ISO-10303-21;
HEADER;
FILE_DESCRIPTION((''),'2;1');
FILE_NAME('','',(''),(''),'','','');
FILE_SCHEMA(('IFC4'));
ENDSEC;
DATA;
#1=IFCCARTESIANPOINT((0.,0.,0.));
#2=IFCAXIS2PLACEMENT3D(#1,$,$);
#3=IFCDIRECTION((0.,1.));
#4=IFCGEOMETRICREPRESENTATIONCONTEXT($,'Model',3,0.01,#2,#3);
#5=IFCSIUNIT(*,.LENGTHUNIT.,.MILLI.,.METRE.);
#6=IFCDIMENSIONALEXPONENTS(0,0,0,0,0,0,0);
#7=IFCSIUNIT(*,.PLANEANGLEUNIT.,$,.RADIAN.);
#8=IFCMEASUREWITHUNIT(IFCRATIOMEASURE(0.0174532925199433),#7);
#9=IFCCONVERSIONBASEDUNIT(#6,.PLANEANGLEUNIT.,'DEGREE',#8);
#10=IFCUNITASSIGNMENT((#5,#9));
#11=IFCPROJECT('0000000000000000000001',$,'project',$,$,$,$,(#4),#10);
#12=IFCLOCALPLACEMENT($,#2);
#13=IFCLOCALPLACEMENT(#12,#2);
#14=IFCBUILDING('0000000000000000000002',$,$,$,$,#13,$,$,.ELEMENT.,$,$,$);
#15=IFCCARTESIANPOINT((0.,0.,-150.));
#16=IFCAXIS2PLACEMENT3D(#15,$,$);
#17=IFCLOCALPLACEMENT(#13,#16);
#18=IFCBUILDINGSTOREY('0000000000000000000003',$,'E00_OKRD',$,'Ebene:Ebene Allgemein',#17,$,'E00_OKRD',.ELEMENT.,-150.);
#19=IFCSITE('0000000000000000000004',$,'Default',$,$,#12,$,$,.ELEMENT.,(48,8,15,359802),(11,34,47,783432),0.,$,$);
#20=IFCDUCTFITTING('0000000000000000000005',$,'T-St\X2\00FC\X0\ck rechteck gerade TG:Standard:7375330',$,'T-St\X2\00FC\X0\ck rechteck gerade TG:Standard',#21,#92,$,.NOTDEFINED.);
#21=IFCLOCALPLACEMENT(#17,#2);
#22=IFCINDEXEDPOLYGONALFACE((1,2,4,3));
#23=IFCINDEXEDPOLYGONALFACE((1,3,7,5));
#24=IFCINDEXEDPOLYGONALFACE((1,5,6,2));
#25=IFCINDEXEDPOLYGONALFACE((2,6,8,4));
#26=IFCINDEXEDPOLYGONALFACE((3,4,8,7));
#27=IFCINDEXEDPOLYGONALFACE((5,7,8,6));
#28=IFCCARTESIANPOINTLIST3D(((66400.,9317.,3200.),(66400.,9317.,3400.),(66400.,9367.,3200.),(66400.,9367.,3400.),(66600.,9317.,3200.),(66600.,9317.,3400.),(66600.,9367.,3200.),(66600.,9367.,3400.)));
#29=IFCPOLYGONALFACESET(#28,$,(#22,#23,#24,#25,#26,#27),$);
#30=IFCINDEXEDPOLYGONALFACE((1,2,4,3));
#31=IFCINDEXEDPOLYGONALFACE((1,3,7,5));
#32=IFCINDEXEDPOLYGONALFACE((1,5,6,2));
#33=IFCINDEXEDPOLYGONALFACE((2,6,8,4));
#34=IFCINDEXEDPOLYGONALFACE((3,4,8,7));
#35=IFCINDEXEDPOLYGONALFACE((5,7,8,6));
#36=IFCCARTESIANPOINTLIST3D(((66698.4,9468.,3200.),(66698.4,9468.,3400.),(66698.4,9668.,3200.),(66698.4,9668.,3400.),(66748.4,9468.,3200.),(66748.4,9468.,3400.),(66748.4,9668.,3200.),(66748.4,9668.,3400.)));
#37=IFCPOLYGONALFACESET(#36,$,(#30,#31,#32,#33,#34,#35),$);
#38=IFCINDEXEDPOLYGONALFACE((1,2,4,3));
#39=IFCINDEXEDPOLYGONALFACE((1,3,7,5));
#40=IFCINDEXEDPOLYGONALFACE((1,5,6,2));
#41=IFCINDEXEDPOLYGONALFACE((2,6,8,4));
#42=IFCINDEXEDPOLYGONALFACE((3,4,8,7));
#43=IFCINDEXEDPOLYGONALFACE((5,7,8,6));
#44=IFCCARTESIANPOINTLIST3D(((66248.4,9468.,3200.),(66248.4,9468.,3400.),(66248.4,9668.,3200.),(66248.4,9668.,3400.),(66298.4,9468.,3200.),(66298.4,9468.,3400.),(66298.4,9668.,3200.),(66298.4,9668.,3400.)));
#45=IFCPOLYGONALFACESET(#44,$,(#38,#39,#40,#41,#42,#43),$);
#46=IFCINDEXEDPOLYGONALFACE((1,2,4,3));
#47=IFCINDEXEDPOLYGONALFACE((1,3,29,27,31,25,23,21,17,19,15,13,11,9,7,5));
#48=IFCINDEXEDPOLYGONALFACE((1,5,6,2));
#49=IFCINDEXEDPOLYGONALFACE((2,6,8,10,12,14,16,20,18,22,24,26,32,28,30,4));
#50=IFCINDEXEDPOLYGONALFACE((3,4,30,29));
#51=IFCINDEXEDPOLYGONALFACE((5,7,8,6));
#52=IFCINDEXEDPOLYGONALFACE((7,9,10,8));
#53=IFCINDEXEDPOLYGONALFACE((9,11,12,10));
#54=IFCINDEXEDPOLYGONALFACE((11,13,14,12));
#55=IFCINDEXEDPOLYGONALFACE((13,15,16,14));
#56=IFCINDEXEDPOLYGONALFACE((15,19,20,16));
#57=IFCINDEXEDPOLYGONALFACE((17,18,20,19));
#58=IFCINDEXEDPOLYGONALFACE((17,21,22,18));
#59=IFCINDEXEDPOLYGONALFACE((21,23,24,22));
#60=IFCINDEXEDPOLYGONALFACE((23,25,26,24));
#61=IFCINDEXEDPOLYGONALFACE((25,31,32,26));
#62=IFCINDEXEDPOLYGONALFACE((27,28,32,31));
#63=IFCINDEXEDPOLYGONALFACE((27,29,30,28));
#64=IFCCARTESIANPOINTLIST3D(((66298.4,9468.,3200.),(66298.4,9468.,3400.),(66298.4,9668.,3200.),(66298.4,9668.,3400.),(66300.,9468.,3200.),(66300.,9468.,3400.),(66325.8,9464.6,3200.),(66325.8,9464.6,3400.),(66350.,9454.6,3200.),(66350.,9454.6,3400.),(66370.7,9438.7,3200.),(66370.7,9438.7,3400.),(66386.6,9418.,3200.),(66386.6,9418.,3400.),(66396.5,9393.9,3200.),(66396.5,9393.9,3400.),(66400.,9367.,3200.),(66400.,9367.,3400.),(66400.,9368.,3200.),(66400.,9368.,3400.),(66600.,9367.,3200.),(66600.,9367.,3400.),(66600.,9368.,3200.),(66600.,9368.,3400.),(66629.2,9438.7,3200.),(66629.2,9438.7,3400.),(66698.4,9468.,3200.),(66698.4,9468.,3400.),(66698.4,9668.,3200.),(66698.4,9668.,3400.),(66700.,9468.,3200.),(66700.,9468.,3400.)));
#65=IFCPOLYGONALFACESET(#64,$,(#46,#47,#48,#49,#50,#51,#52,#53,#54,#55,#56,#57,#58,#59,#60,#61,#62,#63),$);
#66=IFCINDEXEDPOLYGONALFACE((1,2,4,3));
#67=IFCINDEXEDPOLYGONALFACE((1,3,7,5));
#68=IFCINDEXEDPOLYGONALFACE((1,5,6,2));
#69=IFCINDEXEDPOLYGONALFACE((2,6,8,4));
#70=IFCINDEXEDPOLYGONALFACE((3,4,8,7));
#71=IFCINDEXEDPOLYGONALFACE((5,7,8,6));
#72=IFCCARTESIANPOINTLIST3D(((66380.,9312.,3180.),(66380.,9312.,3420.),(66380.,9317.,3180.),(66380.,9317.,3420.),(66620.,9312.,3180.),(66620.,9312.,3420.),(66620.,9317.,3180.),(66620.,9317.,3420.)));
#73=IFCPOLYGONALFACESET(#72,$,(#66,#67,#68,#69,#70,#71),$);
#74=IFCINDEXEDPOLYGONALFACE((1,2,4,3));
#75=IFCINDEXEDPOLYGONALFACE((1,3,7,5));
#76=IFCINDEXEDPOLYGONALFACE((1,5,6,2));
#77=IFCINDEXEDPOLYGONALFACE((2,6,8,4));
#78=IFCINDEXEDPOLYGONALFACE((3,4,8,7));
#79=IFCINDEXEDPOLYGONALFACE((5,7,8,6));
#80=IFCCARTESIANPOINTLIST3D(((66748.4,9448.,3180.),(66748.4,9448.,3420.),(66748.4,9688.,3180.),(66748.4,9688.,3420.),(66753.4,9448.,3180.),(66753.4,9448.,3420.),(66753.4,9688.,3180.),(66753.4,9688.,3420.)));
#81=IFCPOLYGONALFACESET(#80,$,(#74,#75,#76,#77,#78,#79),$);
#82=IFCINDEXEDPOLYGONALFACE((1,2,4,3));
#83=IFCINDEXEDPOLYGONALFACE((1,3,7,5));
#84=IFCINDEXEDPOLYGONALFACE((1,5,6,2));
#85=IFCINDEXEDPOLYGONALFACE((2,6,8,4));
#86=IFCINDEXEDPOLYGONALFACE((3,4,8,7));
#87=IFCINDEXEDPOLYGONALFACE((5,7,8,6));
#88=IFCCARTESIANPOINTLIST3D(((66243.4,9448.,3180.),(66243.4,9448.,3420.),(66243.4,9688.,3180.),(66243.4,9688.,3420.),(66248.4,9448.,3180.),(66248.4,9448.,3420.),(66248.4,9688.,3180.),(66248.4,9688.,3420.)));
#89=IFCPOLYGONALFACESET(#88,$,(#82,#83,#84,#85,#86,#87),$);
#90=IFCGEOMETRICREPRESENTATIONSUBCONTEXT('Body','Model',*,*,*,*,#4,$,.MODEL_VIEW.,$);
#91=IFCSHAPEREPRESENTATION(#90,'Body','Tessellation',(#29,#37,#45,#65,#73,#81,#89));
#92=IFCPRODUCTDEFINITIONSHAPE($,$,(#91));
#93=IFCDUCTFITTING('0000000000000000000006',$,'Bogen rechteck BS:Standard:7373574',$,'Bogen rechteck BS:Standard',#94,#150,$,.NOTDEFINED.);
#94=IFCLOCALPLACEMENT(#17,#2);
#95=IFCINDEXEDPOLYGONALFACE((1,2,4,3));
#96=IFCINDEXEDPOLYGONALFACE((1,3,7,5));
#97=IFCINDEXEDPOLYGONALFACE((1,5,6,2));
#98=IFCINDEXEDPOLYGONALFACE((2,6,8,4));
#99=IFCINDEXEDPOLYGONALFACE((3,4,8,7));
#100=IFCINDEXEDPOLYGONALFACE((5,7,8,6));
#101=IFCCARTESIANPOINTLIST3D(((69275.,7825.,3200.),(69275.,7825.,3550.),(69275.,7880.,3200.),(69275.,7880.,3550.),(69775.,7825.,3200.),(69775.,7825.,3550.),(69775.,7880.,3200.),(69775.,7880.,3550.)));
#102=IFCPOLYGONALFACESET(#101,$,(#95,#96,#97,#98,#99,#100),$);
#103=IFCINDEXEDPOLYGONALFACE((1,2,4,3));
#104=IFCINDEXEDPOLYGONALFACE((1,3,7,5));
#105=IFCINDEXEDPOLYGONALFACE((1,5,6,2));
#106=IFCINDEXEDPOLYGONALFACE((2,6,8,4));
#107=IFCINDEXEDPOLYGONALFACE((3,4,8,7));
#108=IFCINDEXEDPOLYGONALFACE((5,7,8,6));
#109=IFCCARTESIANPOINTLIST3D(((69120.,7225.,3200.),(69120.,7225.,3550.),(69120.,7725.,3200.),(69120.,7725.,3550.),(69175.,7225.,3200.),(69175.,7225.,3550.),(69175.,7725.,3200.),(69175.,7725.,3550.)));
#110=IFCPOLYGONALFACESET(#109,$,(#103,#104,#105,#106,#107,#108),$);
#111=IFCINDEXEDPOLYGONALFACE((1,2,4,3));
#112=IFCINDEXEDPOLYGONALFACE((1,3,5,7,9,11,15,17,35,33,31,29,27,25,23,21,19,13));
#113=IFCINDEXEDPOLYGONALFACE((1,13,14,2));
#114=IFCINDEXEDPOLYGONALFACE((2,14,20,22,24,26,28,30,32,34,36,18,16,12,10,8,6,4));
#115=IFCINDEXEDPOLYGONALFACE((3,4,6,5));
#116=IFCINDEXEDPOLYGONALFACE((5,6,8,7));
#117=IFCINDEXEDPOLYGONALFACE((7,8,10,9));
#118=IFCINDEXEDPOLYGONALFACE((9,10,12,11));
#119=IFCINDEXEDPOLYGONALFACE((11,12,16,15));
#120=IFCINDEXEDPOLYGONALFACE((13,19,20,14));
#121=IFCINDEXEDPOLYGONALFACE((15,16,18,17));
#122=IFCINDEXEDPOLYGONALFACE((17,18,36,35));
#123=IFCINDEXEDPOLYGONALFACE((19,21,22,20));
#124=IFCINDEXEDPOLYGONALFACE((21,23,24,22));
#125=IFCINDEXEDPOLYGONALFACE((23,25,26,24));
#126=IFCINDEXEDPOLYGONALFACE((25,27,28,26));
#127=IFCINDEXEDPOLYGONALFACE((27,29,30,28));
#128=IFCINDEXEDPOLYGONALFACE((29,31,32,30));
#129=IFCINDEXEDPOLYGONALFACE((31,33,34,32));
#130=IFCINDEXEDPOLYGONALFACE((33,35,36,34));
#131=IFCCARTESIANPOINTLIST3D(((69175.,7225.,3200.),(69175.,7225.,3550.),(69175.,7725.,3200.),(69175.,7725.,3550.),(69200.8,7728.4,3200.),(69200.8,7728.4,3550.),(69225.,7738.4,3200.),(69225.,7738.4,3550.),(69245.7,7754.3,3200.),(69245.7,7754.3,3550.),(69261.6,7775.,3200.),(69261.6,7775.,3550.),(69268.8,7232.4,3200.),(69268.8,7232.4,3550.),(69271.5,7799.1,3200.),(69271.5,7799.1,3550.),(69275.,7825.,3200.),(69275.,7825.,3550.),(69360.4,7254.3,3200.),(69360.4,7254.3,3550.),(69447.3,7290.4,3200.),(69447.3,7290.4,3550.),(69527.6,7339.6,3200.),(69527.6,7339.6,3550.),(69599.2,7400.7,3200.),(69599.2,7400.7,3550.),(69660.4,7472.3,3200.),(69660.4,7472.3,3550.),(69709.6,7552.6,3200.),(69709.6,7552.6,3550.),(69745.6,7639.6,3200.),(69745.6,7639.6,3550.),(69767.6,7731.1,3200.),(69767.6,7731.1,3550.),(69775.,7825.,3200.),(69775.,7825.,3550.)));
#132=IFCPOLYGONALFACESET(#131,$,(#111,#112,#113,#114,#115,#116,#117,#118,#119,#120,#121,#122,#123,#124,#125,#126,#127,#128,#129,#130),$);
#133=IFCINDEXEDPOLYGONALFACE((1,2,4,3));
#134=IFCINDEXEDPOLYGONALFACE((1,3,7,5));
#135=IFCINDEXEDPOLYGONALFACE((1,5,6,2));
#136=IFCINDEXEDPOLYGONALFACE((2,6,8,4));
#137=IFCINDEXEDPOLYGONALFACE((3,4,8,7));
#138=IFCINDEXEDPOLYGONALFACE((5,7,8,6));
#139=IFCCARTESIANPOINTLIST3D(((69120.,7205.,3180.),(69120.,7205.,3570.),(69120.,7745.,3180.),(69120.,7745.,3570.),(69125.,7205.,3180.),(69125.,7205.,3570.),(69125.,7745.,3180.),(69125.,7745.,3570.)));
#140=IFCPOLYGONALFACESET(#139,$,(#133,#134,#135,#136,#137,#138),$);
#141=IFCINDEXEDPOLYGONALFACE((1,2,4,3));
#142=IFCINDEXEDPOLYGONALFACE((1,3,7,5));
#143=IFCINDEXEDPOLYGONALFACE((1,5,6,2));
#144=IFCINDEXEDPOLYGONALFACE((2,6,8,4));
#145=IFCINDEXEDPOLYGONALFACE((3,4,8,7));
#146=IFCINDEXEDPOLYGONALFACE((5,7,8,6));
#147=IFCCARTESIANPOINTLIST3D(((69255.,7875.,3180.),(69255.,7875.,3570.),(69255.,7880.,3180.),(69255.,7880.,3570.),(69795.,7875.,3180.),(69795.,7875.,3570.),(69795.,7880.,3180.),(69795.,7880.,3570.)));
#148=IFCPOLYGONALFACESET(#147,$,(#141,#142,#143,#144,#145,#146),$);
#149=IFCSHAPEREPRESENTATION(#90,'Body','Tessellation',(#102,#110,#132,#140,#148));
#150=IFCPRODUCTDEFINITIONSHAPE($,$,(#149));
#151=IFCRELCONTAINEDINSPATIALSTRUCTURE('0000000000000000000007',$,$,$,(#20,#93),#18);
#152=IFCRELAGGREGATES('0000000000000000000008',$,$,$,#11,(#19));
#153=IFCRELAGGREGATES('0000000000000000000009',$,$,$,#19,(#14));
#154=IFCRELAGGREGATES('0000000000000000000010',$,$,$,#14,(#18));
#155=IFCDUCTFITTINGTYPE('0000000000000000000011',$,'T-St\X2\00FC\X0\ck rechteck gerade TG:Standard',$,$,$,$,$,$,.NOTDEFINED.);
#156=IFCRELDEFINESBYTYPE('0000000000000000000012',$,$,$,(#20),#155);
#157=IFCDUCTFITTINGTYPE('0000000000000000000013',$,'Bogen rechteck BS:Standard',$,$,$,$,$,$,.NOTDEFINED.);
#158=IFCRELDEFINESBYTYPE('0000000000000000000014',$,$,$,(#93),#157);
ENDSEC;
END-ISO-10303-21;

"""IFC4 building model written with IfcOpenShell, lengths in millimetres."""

from ifc_helpers import new_model, entity, si_unit, converted_unit, direction, frame, frame_2d, origin, origin_2d_with_axis, place, context, subcontext, project, spatial, polyline, circle_curve, parameter, trimmed, segment, composite_curve, rectangle, outline, extrude, source, transform, mapped, type_object, type_shapes, element, save


model = new_model("IFC4")

# Units and contexts
model_context = context("Model", 3, precision=0.01, world=origin(), true_north=direction((0.0, 1.0)))
body_context = subcontext(model_context, "Body", "Model", "MODEL_VIEW")
ifc_project = project(units=[si_unit("LENGTHUNIT", "METRE", prefix="MILLI"), converted_unit("PLANEANGLEUNIT", "DEGREE", entity("IfcRatioMeasure", 0.0174532925199433), si_unit("PLANEANGLEUNIT", "RADIAN"), dimensions=[0, 0, 0, 0, 0, 0, 0])], contexts=[model_context])

# Site, building, storey
site_placement = place(None, origin())
site = spatial("IfcSite", under=ifc_project, at=site_placement, Name="Default", CompositionType="ELEMENT", RefLatitude=(48, 8, 15, 359802), RefLongitude=(11, 34, 47, 783432), RefElevation=0.0)
building_placement = place(site_placement, origin())
building = spatial("IfcBuilding", under=site, at=building_placement, CompositionType="ELEMENT")
storey_placement = place(building_placement, frame((0.0, 0.0, -150.0)))
storey = spatial("IfcBuildingStorey", under=building, at=storey_placement, Name="E00_OKRD", ObjectType="Ebene:Ebene Allgemein", LongName="E00_OKRD", CompositionType="ELEMENT", Elevation=-150.0)

# Duct fittings
duct_fitting_type_1 = type_object("IfcDuctFittingType", Name="T-Stück rechteck gerade TG:Standard", PredefinedType="NOTDEFINED")
shared_shape_1 = source(origin(), body_context, "Body", "SweptSolid", [
    extrude(rectangle(XDim=50.0, YDim=200.0, at=frame_2d((0.0, 0.0), x_axis=(1.0, 0.0))), frame((0.0, -226.0, -100.0), z_axis=(0.0, 0.0, 1.0), x_axis=(0.0, -1.0, 0.0)), (0.0, 0.0, 1.0), 200.0),
    extrude(rectangle(XDim=50.0, YDim=200.0, at=frame_2d((0.0, 0.0), x_axis=(1.0, 0.0))), frame((223.4, 0.0, -100.0), z_axis=(0.0, 0.0, 1.0), x_axis=(-1.0, 0.0, 0.0)), (0.0, 0.0, 1.0), 200.0),
    extrude(rectangle(XDim=50.0, YDim=200.0, at=frame_2d((0.0, 0.0), x_axis=(1.0, 0.0))), frame((-226.6, 0.0, -100.0)), (0.0, 0.0, 1.0), 200.0),
    extrude(outline(composite_curve([segment(trimmed(circle_curve(frame_2d((-200.6, -99.8), x_axis=(-1.0, 0.0)), 100.0), [parameter(180.0)], [parameter(270.0)], True, "PARAMETER"), False, "CONTINUOUS"), segment(polyline([(-100.6, -99.8), (-100.6, -100.8)]), True, "CONTINUOUS"), segment(polyline([(-100.6, -100.8), (99.4, -100.8)]), True, "CONTINUOUS"), segment(polyline([(99.4, -100.8), (99.4, -99.8)]), True, "CONTINUOUS"), segment(trimmed(circle_curve(frame_2d((199.4, -99.8), x_axis=(-1.0, 0.0)), 100.0), [parameter(270.0)], [parameter(0.0)], True, "PARAMETER"), False, "CONTINUOUS"), segment(polyline([(199.4, 0.2), (201.0, 0.2)]), True, "CONTINUOUS"), segment(polyline([(201.0, 0.2), (201.0, 200.2)]), True, "CONTINUOUS"), segment(polyline([(201.0, 200.2), (-199.0, 200.2)]), True, "CONTINUOUS"), segment(polyline([(-199.0, 200.2), (-199.0, 0.2)]), True, "CONTINUOUS"), segment(polyline([(-199.0, 0.2), (-200.6, 0.2)]), True, "CONTINUOUS")], self_intersect=False)), frame((-0.6, -100.2, -100.0), z_axis=(0.0, 0.0, -1.0), x_axis=(-1.0, 0.0, 0.0)), (0.0, 0.0, -1.0), 200.0),
    extrude(rectangle(XDim=5.0, YDim=240.0, at=frame_2d((0.0, 0.0), x_axis=(1.0, 0.0))), frame((0.0, -253.5, -120.0), z_axis=(0.0, 0.0, 1.0), x_axis=(0.0, 1.0, 0.0)), (0.0, 0.0, 1.0), 240.0),
    extrude(rectangle(XDim=5.0, YDim=240.0, at=origin_2d_with_axis()), frame((250.9, 0.0, -120.0), z_axis=(0.0, 0.0, 1.0), x_axis=(-1.0, 0.0, 0.0)), (0.0, 0.0, 1.0), 240.0),
    extrude(rectangle(XDim=5.0, YDim=240.0, at=origin_2d_with_axis()), frame((-254.1, 0.0, -120.0), z_axis=(0.0, 0.0, 1.0), x_axis=(-1.0, 0.0, 0.0)), (0.0, 0.0, 1.0), 240.0),
])
type_shapes(duct_fitting_type_1, [shared_shape_1])
duct_fitting_1_placement = place(storey_placement, frame((66500.0, 9568.0, 3300.0)))
element("IfcDuctFitting", 1, at=duct_fitting_1_placement, inside=storey, type_object=duct_fitting_type_1, Name="T-Stück rechteck gerade TG:Standard:7375330", ObjectType="T-Stück rechteck gerade TG:Standard", PredefinedType="NOTDEFINED", context=body_context, shape_type="MappedRepresentation", body=[
    mapped(shared_shape_1, transform((0.0, 0.0, 0.0), scale=1.0)),
])
duct_fitting_type_2 = type_object("IfcDuctFittingType", Name="Bogen rechteck BS:Standard", PredefinedType="NOTDEFINED")
shared_shape_2 = source(origin(), body_context, "Body", "SweptSolid", [
    extrude(rectangle(XDim=55.0, YDim=500.0, at=frame_2d((0.0, 0.0), x_axis=(1.0, 0.0))), frame((0.0, 377.5, -175.0), z_axis=(0.0, 0.0, 1.0), x_axis=(0.0, 1.0, 0.0)), (0.0, 0.0, 1.0), 350.0),
    extrude(rectangle(XDim=500.0, YDim=55.0, at=frame_2d((0.0, 0.0), x_axis=(1.0, 0.0))), frame((-377.5, 0.0, -175.0), z_axis=(0.0, 0.0, 1.0), x_axis=(0.0, -1.0, 0.0)), (0.0, 0.0, 1.0), 350.0),
    extrude(outline(composite_curve([segment(polyline([(-425.0, -175.0), (75.0, -175.0)]), True, "CONTINUOUS"), segment(trimmed(circle_curve(frame_2d((175.0, -175.0), x_axis=(0.0, 1.0)), 100.0), [parameter(0.0)], [parameter(90.0)], True, "PARAMETER"), False, "CONTINUOUS"), segment(polyline([(175.0, -75.0), (175.0, 425.0)]), True, "CONTINUOUS"), segment(trimmed(circle_curve(frame_2d((175.0, -175.0), x_axis=(0.0, 1.0)), 600.0), [parameter(0.0)], [parameter(90.0)], True, "PARAMETER"), True, "CONTINUOUS")], self_intersect=False)), frame((-175.0, 175.0, -175.0), z_axis=(0.0, 0.0, 1.0), x_axis=(-1.0, 0.0, 0.0)), (0.0, 0.0, 1.0), 350.0),
    extrude(rectangle(XDim=5.0, YDim=540.0, at=frame_2d((0.0, 0.0), x_axis=(1.0, 0.0))), frame((-402.5, 0.0, -195.0)), (0.0, 0.0, 1.0), 390.0),
    extrude(rectangle(XDim=5.0, YDim=540.0, at=origin_2d_with_axis()), frame((0.0, 402.5, -195.0), z_axis=(0.0, 0.0, 1.0), x_axis=(0.0, 1.0, 0.0)), (0.0, 0.0, 1.0), 390.0),
])
type_shapes(duct_fitting_type_2, [shared_shape_2])
duct_fitting_2_placement = place(storey_placement, frame((69525.0, 7475.0, 3375.0)))
element("IfcDuctFitting", 2, at=duct_fitting_2_placement, inside=storey, type_object=duct_fitting_type_2, Name="Bogen rechteck BS:Standard:7373574", ObjectType="Bogen rechteck BS:Standard", PredefinedType="NOTDEFINED", context=body_context, shape_type="MappedRepresentation", body=[
    mapped(shared_shape_2, transform((0.0, 0.0, 0.0), scale=1.0)),
])

save(model, "model.ifc")
